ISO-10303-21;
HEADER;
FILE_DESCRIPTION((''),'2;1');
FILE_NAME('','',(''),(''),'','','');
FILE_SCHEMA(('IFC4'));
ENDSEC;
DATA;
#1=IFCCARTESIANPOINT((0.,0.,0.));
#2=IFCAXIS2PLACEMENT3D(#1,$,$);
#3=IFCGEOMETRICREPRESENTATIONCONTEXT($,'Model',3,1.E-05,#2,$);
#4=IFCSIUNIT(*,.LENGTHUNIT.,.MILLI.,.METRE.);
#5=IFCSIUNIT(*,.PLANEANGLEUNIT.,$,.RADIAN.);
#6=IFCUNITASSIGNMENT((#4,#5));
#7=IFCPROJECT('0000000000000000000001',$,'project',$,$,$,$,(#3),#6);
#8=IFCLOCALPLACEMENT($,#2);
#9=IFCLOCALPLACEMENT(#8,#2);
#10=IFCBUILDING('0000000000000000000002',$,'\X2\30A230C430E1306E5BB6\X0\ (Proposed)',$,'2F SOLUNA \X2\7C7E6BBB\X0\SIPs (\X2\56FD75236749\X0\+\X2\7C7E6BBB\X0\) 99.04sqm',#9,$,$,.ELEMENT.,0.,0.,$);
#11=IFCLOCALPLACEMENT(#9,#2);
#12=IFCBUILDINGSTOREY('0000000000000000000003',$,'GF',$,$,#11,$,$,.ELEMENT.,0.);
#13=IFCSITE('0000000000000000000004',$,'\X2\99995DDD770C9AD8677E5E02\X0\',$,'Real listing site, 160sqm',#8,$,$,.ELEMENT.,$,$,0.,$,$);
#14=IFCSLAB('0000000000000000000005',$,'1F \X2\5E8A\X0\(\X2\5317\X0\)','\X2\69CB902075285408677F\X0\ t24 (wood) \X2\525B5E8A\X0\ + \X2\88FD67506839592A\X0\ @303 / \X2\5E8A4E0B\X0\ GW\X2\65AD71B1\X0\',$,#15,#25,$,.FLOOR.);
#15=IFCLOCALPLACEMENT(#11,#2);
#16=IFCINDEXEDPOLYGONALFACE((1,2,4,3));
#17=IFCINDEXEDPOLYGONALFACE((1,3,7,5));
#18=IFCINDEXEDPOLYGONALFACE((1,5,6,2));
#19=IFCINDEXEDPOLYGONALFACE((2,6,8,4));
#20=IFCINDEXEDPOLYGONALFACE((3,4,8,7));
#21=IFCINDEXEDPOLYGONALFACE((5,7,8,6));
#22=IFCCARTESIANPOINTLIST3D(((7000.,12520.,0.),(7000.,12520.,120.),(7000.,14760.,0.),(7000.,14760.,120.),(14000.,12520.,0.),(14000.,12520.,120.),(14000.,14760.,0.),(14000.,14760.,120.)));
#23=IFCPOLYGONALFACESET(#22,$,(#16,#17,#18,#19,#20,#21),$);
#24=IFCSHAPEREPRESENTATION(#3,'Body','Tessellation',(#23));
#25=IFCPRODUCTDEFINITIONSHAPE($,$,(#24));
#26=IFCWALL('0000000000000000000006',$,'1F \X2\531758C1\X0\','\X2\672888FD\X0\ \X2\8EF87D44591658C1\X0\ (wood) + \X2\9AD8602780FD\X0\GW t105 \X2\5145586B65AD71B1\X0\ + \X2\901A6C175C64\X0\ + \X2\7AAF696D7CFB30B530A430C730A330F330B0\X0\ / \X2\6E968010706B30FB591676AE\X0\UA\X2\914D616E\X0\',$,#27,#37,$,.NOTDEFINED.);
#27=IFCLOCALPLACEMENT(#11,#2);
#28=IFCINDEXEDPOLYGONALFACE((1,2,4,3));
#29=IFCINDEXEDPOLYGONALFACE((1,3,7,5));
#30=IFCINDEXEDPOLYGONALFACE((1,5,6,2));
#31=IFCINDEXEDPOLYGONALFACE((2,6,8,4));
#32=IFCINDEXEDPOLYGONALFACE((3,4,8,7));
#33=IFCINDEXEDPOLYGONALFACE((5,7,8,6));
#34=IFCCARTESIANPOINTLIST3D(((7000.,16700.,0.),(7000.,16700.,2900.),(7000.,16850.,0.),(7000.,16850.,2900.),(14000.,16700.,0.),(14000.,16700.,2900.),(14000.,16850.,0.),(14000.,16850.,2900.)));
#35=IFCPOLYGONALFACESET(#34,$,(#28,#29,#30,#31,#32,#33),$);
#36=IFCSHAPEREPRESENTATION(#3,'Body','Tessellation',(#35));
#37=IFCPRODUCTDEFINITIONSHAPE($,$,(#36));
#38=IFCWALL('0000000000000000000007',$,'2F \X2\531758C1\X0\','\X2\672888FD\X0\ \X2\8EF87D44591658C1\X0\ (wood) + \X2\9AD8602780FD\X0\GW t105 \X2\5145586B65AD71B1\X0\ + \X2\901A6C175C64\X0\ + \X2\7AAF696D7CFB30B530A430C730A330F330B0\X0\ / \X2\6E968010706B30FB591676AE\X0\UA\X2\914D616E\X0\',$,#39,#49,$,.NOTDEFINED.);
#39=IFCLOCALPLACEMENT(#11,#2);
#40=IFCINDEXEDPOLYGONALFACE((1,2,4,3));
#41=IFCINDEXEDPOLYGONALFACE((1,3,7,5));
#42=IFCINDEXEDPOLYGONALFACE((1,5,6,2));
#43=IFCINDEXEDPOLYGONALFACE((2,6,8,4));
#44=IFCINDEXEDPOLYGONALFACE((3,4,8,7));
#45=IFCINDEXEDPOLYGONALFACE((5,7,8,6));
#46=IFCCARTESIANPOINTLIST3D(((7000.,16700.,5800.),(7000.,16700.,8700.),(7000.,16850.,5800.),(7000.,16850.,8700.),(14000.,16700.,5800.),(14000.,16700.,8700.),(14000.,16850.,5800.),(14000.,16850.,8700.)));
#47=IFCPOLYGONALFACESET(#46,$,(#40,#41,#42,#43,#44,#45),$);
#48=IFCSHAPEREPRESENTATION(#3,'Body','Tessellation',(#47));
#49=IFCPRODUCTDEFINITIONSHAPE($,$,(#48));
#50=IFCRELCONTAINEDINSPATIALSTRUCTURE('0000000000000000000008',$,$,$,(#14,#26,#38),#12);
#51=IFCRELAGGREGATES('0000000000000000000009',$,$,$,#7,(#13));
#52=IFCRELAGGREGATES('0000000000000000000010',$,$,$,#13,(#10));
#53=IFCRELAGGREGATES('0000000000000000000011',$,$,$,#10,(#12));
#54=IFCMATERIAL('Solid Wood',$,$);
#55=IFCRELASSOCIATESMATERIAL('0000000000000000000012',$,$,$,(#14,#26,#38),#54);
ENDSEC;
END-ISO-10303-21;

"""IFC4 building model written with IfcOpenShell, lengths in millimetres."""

from ifc_helpers import new_model, si_unit, frame, frame_2d, origin, place, context, project, spatial, rectangle, extrude, material, element, save


model = new_model("IFC4")

# Units and contexts
model_context = context("Model", 3, precision=1e-05, world=origin())
ifc_project = project(units=[si_unit("LENGTHUNIT", "METRE", prefix="MILLI"), si_unit("PLANEANGLEUNIT", "RADIAN")], contexts=[model_context])

# Site, building, storey
site_placement = place(None, origin())
site = spatial("IfcSite", under=ifc_project, at=site_placement, Name="香川県高松市", ObjectType="Real listing site, 160sqm", CompositionType="ELEMENT", RefElevation=0.0)
building_placement = place(site_placement, origin())
building = spatial("IfcBuilding", under=site, at=building_placement, Name="アツメの家 (Proposed)", ObjectType="2F SOLUNA 籾殻SIPs (国産杉+籾殻) 99.04sqm", CompositionType="ELEMENT", ElevationOfRefHeight=0.0, ElevationOfTerrain=0.0)
storey_placement = place(building_placement, origin())
storey = spatial("IfcBuildingStorey", under=building, at=storey_placement, Name="GF", CompositionType="ELEMENT", Elevation=0.0)

# Slab
ifc_material_1 = material(Name="Solid Wood")
slab_1_placement = place(storey_placement, frame((3500.0, 6260.0, 0.0)))
element("IfcSlab", 1, at=slab_1_placement, inside=storey, material=ifc_material_1, Name="1F 床(北)", Description="構造用合板 t24 (wood) 剛床 + 製材根太 @303 / 床下 GW断熱", PredefinedType="FLOOR", context=model_context, shape_type="SweptSolid", body=[
    extrude(rectangle(XDim=7000.0, YDim=2240.0, at=frame_2d((3500.0, 1120.0))), frame((3500.0, 6260.0, 0.0)), (0.0, 0.0, 1.0), 120.0),
])

# Wall
wall_1_placement = place(storey_placement, frame((3500.0, 8350.0, 0.0)))
element("IfcWall", 2, at=wall_1_placement, inside=storey, material=ifc_material_1, Name="1F 北壁", Description="木製 軸組外壁 (wood) + 高性能GW t105 充填断熱 + 通気層 + 窯業系サイディング / 準耐火・外皮UA配慮", PredefinedType="NOTDEFINED", context=model_context, shape_type="SweptSolid", body=[
    extrude(rectangle(XDim=7000.0, YDim=150.0, at=frame_2d((3500.0, 75.0))), frame((3500.0, 8350.0, 0.0)), (0.0, 0.0, 1.0), 2900.0),
])

# Wall
wall_2_placement = place(storey_placement, frame((3500.0, 8350.0, 2900.0)))
element("IfcWall", 3, at=wall_2_placement, inside=storey, material=ifc_material_1, Name="2F 北壁", Description="木製 軸組外壁 (wood) + 高性能GW t105 充填断熱 + 通気層 + 窯業系サイディング / 準耐火・外皮UA配慮", PredefinedType="NOTDEFINED", context=model_context, shape_type="SweptSolid", body=[
    extrude(rectangle(XDim=7000.0, YDim=150.0, at=frame_2d((3500.0, 75.0))), frame((3500.0, 8350.0, 2900.0)), (0.0, 0.0, 1.0), 2900.0),
])

save(model, "model.ifc")
